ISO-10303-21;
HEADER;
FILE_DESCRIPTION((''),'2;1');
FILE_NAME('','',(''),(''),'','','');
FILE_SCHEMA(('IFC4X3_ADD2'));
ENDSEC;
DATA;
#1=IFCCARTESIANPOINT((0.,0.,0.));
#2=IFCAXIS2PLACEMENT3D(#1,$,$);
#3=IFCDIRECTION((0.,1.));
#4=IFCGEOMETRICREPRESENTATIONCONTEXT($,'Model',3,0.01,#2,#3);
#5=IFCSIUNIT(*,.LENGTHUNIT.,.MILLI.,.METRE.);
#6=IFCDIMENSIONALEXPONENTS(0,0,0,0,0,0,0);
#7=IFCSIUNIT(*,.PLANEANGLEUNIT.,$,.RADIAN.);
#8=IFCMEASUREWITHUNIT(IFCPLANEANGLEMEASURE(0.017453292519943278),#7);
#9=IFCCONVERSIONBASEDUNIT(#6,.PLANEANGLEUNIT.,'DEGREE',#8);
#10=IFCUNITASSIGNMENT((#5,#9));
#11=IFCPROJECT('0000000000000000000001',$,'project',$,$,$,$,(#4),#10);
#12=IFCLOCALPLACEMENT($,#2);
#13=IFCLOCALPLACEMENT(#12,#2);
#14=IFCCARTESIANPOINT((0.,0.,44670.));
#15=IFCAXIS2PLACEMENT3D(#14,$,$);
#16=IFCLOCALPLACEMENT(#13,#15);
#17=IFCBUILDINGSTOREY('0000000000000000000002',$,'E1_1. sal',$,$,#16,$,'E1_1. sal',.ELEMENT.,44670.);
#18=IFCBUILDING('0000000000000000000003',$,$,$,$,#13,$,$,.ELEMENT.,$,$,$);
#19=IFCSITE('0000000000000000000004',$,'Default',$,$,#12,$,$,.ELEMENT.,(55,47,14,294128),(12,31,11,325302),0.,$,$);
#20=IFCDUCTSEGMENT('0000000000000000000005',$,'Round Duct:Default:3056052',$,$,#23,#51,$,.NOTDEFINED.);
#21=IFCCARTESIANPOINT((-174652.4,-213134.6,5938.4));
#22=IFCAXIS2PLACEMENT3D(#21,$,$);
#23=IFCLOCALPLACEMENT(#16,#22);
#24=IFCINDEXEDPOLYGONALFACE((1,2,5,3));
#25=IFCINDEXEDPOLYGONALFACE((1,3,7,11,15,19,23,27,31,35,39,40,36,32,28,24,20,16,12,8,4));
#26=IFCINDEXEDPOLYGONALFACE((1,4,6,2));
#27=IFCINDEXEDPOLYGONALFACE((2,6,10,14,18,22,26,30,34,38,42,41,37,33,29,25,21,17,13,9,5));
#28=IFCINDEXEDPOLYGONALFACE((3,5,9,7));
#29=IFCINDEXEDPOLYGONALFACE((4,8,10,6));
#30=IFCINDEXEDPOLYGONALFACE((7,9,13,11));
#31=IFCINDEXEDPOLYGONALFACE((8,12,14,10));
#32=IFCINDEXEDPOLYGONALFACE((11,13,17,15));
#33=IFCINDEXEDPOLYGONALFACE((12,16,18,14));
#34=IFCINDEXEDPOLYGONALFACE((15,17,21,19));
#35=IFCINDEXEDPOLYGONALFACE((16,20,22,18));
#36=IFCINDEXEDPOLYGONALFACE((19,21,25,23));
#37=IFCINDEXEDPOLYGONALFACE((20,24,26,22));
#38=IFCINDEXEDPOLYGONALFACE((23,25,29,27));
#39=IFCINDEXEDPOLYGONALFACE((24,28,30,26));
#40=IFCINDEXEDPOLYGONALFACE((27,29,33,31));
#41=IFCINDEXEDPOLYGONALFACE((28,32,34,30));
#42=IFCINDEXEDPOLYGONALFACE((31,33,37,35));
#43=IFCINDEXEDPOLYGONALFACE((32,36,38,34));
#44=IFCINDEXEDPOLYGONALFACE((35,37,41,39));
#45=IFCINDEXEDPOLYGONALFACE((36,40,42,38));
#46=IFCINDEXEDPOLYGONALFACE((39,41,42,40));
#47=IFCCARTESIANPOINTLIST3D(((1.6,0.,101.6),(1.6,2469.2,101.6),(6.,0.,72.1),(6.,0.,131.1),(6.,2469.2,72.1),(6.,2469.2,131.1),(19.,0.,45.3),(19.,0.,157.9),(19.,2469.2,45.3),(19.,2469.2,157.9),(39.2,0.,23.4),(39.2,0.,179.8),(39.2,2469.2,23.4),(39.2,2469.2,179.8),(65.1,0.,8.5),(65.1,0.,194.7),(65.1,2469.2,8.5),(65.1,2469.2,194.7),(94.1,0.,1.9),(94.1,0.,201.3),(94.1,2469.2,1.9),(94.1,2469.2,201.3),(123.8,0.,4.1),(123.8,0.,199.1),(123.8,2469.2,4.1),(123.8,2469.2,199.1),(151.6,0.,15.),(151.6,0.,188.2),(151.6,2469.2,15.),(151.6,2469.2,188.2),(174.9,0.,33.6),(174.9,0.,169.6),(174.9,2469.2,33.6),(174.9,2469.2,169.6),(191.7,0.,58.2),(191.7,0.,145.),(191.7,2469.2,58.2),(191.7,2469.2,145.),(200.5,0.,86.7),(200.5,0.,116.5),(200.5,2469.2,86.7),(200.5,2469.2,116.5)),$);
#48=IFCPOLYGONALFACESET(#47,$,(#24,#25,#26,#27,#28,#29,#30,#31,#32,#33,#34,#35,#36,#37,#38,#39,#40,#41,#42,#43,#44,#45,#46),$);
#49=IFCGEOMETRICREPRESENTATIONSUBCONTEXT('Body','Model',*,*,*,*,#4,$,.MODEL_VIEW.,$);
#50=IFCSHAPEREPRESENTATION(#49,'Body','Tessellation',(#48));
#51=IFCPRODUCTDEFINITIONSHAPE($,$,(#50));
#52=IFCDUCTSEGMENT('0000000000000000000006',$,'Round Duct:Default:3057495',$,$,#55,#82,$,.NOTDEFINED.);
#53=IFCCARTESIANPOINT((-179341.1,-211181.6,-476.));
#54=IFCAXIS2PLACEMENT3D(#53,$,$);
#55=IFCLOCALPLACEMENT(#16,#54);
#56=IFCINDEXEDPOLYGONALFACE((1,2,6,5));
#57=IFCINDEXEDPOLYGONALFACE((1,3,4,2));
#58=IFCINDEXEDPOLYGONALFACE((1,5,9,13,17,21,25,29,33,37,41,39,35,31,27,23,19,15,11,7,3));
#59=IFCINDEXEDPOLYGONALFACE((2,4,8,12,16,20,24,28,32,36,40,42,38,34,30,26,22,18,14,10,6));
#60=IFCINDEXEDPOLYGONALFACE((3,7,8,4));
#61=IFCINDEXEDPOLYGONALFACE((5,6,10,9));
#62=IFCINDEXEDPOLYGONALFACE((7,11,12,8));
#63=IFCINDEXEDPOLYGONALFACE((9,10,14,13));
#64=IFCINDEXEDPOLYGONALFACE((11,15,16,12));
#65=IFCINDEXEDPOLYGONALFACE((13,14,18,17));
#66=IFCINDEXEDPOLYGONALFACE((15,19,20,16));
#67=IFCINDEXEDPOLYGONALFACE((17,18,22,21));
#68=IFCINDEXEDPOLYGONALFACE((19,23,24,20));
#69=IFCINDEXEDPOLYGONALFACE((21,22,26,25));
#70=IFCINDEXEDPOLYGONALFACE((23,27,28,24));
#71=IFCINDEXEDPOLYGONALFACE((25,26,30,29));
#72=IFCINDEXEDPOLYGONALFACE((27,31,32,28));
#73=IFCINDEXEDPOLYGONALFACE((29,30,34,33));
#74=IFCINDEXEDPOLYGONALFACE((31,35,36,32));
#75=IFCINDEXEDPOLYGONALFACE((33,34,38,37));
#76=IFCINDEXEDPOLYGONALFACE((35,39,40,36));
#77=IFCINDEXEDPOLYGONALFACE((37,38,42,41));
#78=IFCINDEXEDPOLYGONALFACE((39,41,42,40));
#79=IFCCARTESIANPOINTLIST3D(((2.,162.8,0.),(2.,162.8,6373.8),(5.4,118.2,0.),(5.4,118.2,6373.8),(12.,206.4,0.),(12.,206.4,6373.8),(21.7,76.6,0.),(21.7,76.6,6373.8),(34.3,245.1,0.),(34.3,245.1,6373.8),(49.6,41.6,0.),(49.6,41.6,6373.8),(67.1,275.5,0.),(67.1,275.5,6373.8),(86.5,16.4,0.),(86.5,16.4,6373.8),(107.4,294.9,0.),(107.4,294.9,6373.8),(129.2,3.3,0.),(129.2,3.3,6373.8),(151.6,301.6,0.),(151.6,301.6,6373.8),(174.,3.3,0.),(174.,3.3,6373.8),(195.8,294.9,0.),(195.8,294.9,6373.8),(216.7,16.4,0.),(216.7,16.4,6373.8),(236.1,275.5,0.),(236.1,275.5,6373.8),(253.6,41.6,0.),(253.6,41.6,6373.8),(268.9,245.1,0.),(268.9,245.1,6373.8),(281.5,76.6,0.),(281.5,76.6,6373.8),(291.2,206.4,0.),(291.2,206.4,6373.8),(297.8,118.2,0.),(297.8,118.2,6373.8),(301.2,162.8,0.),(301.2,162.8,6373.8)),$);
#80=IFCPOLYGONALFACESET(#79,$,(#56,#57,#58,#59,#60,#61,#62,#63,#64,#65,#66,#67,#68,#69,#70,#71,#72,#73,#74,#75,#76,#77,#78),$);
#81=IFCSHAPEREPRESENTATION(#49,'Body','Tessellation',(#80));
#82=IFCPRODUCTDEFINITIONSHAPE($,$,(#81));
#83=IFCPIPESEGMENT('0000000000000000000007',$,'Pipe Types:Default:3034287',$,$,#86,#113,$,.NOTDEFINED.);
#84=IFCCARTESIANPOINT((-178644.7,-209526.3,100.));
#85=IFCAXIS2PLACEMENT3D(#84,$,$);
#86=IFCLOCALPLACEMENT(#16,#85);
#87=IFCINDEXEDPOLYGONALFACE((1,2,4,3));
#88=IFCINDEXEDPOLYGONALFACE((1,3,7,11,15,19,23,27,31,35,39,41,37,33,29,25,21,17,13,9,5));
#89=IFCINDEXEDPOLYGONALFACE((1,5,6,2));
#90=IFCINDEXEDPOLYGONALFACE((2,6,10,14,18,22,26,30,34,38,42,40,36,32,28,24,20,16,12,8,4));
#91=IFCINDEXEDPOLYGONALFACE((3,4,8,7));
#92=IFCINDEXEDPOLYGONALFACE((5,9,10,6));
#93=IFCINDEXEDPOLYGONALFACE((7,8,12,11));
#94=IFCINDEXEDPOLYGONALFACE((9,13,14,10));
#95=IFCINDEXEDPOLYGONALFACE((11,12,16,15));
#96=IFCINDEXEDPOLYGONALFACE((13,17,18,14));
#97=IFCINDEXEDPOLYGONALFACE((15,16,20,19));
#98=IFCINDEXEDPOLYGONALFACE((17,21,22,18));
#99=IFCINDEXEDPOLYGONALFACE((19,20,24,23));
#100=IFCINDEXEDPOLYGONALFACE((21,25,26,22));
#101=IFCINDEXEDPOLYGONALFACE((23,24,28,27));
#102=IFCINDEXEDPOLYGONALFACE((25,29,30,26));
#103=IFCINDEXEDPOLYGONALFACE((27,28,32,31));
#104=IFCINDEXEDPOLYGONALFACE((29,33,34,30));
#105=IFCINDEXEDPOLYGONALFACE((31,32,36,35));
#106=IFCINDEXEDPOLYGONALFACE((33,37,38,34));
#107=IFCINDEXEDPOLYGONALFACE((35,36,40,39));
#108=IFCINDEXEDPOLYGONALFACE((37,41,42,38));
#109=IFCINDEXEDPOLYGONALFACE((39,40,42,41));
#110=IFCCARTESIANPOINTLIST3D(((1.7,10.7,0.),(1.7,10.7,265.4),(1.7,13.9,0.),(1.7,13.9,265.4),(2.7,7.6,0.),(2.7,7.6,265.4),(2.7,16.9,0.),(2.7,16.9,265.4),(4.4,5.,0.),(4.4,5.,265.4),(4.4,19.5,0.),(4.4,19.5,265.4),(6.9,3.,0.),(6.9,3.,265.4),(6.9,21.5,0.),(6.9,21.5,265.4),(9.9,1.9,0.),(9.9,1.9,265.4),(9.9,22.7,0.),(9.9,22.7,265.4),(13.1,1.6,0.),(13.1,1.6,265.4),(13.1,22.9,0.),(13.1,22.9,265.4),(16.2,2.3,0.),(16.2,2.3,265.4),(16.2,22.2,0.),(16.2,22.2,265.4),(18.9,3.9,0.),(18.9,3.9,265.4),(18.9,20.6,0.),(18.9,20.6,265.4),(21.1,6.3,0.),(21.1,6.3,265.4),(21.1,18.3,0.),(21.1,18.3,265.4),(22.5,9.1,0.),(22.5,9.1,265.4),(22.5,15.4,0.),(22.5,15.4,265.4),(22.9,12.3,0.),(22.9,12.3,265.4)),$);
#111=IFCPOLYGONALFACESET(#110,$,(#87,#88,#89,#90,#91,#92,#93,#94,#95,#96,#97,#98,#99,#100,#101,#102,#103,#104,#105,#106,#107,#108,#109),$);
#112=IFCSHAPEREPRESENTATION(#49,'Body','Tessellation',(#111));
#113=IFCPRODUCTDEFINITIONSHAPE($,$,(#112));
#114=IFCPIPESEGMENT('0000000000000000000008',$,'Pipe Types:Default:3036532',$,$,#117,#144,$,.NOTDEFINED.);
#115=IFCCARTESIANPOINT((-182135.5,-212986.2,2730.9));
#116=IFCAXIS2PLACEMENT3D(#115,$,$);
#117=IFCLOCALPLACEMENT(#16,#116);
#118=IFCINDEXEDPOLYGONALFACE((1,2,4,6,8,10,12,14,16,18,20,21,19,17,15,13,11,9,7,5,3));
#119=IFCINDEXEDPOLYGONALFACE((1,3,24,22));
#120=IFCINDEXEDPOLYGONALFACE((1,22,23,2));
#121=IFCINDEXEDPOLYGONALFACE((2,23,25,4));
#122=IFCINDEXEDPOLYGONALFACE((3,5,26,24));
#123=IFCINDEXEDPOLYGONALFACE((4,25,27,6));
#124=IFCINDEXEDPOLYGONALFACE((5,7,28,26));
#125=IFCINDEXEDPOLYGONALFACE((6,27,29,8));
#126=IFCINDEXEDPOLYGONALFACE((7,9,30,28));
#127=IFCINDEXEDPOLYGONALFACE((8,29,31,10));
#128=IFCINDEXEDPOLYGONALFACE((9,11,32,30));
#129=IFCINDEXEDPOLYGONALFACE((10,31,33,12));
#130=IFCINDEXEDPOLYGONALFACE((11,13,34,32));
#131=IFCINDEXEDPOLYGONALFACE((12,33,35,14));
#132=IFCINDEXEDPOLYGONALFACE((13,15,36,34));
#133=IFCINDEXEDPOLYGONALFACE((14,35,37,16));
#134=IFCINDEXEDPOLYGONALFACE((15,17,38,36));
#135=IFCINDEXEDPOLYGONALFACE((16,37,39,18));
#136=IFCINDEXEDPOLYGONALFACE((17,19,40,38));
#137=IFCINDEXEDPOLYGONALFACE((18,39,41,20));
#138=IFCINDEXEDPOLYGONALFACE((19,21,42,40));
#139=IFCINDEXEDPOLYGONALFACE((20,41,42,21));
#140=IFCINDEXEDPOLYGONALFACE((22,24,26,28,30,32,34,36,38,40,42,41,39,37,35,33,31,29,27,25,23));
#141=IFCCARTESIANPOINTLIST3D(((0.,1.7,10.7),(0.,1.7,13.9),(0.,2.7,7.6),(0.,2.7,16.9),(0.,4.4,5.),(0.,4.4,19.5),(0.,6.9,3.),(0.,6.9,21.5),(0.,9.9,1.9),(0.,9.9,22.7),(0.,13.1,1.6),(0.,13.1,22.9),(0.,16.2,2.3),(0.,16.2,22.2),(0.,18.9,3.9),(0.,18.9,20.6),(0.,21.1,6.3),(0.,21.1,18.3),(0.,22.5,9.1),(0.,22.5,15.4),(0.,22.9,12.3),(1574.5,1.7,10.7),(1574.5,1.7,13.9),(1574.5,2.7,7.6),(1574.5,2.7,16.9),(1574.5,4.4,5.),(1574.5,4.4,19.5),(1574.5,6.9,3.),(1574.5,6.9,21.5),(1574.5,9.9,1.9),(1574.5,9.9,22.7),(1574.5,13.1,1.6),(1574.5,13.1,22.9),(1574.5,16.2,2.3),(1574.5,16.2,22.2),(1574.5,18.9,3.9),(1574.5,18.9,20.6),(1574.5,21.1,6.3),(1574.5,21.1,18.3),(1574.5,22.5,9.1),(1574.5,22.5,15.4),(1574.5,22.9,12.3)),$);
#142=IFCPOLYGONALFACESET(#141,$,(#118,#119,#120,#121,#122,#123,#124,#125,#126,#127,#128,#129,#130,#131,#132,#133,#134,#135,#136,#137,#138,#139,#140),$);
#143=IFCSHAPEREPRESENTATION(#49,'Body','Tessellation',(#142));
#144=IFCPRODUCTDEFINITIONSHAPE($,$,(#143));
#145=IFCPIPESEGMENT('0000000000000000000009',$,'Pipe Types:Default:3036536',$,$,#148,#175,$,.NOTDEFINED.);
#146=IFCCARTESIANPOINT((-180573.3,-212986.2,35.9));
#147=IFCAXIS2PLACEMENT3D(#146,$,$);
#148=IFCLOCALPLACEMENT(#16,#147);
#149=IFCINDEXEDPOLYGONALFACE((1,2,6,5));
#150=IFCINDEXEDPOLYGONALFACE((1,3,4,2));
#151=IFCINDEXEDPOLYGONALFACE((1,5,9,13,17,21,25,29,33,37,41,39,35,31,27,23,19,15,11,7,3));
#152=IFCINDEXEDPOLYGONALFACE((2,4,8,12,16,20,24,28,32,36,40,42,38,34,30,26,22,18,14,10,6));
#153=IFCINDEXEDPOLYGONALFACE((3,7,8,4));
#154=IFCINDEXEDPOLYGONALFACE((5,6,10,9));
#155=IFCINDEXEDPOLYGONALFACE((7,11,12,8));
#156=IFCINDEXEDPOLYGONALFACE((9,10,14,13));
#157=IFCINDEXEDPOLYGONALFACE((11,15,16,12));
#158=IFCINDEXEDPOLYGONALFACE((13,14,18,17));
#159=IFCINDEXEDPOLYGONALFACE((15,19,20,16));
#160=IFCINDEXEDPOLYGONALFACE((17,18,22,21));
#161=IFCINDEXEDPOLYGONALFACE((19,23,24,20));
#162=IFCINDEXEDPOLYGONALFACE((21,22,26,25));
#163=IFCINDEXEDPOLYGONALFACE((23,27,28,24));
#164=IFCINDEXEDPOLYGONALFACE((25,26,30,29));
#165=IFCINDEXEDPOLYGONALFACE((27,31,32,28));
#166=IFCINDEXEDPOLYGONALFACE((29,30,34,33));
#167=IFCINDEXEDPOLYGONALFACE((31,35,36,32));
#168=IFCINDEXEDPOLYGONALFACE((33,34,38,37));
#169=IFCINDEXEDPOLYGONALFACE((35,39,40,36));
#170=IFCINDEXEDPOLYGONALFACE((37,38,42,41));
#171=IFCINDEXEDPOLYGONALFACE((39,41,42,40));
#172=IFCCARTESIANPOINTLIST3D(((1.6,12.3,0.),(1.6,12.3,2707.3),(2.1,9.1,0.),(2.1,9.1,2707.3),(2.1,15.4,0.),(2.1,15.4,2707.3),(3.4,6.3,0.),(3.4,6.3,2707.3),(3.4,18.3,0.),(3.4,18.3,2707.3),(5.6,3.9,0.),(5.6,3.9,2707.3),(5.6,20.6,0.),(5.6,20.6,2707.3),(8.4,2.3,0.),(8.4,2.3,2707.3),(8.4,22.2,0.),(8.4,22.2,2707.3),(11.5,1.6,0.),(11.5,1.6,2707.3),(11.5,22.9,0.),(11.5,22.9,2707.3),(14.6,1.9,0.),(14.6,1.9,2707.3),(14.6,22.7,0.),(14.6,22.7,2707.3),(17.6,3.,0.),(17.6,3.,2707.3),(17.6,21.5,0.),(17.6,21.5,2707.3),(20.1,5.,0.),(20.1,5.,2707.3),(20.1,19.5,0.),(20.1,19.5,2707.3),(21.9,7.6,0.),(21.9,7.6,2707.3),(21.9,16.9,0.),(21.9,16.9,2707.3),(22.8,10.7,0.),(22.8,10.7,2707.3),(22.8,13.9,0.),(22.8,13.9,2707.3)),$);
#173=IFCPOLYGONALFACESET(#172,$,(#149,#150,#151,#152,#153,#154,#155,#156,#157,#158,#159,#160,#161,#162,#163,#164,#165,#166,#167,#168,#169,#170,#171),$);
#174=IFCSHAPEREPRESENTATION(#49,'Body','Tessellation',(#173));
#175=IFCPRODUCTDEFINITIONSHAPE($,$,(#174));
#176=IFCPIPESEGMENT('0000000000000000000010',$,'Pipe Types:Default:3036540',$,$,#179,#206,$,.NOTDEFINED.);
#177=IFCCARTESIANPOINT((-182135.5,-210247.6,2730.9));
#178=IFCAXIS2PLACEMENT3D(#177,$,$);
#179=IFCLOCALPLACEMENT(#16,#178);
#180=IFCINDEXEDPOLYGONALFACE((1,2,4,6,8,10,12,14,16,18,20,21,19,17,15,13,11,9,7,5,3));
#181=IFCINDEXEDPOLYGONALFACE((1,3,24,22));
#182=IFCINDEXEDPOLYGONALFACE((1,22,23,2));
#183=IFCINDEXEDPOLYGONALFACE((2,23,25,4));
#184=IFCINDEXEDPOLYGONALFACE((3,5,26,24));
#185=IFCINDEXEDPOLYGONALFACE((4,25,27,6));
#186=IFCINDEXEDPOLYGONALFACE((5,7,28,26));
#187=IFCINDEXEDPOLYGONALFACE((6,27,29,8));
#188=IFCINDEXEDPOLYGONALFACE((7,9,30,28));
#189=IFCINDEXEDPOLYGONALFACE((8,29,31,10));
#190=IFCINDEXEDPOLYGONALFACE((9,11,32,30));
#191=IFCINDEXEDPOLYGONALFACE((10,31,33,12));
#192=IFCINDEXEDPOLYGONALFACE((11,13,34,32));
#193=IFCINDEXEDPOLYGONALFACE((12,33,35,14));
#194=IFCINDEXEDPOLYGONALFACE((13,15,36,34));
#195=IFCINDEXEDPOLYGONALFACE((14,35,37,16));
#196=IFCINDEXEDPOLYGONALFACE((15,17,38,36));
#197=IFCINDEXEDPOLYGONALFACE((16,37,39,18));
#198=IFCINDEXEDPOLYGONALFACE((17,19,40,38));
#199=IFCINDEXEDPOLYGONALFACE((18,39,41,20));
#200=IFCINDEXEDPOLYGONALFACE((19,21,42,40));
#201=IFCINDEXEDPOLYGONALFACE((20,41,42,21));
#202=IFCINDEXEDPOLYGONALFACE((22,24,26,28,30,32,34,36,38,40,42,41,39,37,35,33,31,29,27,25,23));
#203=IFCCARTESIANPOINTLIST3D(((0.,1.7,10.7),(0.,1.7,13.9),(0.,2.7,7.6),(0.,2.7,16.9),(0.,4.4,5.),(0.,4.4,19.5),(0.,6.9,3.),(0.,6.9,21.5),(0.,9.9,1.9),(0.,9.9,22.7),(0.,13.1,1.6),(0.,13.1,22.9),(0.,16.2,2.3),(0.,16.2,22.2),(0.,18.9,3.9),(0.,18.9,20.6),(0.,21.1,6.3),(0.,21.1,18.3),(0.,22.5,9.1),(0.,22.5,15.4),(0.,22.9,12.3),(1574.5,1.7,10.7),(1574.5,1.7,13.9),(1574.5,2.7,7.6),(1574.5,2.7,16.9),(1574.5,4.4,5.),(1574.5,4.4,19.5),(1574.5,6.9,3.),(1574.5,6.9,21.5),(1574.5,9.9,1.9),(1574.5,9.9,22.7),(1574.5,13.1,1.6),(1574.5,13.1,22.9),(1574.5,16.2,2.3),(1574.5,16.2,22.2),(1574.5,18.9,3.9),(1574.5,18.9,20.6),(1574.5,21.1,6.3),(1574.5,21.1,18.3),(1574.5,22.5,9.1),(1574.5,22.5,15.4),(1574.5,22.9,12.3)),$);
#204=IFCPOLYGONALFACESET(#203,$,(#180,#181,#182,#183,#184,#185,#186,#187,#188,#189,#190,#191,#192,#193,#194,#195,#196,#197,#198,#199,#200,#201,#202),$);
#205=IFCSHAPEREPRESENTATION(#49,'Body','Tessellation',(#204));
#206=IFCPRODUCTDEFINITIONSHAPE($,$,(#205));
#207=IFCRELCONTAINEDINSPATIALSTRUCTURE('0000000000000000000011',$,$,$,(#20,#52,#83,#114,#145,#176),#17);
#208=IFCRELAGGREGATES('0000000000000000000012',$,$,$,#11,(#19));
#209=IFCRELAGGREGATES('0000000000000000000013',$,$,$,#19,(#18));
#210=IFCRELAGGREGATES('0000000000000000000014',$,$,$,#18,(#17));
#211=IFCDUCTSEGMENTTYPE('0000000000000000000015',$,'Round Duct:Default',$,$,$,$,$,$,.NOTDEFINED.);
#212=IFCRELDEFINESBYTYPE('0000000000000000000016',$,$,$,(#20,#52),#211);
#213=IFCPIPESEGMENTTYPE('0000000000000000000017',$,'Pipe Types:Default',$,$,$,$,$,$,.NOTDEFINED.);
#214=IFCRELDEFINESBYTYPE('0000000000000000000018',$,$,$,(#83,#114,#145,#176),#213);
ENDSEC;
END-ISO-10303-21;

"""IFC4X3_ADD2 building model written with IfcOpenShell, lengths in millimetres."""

from ifc_helpers import new_model, entity, si_unit, converted_unit, direction, frame, frame_2d, origin, origin_2d_with_axis, place, context, subcontext, project, spatial, circle, extrude, type_object, element, save


model = new_model("IFC4X3_ADD2")

# Units and contexts
model_context = context("Model", 3, precision=0.01, world=origin(), true_north=direction((0.0, 1.0)))
body_context = subcontext(model_context, "Body", "Model", "MODEL_VIEW")
ifc_project = project(units=[si_unit("LENGTHUNIT", "METRE", prefix="MILLI"), converted_unit("PLANEANGLEUNIT", "DEGREE", entity("IfcPlaneAngleMeasure", 0.017453292519943278), si_unit("PLANEANGLEUNIT", "RADIAN"), dimensions=[0, 0, 0, 0, 0, 0, 0])], contexts=[model_context])

# Site, building, storey
site_placement = place(None, origin())
site = spatial("IfcSite", under=ifc_project, at=site_placement, Name="Default", CompositionType="ELEMENT", RefLatitude=(55, 47, 14, 294128), RefLongitude=(12, 31, 11, 325302), RefElevation=0.0)
building_placement = place(site_placement, origin())
building = spatial("IfcBuilding", under=site, at=building_placement, CompositionType="ELEMENT")
storey_placement = place(building_placement, frame((0.0, 0.0, 44670.0)))
storey = spatial("IfcBuildingStorey", under=building, at=storey_placement, Name="E1_1. sal", LongName="E1_1. sal", CompositionType="ELEMENT", Elevation=44670.0)

# Duct segments
duct_segment_type = type_object("IfcDuctSegmentType", Name="Round Duct:Default", PredefinedType="NOTDEFINED")
duct_segment_1_placement = place(storey_placement, frame((-174652.4, -213134.6, 5938.4)))
element("IfcDuctSegment", 1, at=duct_segment_1_placement, inside=storey, type_object=duct_segment_type, Name="Round Duct:Default:3056052", PredefinedType="NOTDEFINED", context=body_context, shape_type="SweptSolid", body=[
    extrude(circle(Radius=100.0, at=origin_2d_with_axis()), frame((101.6, 0.0, 101.6), z_axis=(0.0, 1.0, 0.0), x_axis=(-1.0, 0.0, 0.0)), (0.0, 0.0, 1.0), 2469.2),
])
duct_segment_2_placement = place(storey_placement, frame((-179341.1, -211181.6, -476.0)))
element("IfcDuctSegment", 2, at=duct_segment_2_placement, inside=storey, type_object=duct_segment_type, Name="Round Duct:Default:3057495", PredefinedType="NOTDEFINED", context=body_context, shape_type="SweptSolid", body=[
    extrude(circle(Radius=150.0, at=origin_2d_with_axis()), frame((151.6, 151.6, 0.0), z_axis=(0.0, 0.0, 1.0), x_axis=(0.0, 1.0, 0.0)), (0.0, 0.0, 1.0), 6373.8),
])

# Pipe segments
pipe_segment_type = type_object("IfcPipeSegmentType", Name="Pipe Types:Default", PredefinedType="NOTDEFINED")
pipe_segment_1_placement = place(storey_placement, frame((-178644.7, -209526.3, 100.0)))
element("IfcPipeSegment", 3, at=pipe_segment_1_placement, inside=storey, type_object=pipe_segment_type, Name="Pipe Types:Default:3034287", PredefinedType="NOTDEFINED", context=body_context, shape_type="SweptSolid", body=[
    extrude(circle(Radius=10.7, at=frame_2d((0.0, 0.0), x_axis=(1.0, 0.0))), frame((12.3, 12.3, 0.0)), (0.0, 0.0, 1.0), 265.4),
])
pipe_segment_2_placement = place(storey_placement, frame((-182135.5, -212986.2, 2730.9)))
element("IfcPipeSegment", 4, at=pipe_segment_2_placement, inside=storey, type_object=pipe_segment_type, Name="Pipe Types:Default:3036532", PredefinedType="NOTDEFINED", context=body_context, shape_type="SweptSolid", body=[
    extrude(circle(Radius=10.7, at=origin_2d_with_axis()), frame((0.0, 12.3, 12.3), z_axis=(1.0, 0.0, 0.0), x_axis=(0.0, 1.0, 0.0)), (0.0, 0.0, 1.0), 1574.5),
])
pipe_segment_3_placement = place(storey_placement, frame((-180573.3, -212986.2, 35.9)))
element("IfcPipeSegment", 5, at=pipe_segment_3_placement, inside=storey, type_object=pipe_segment_type, Name="Pipe Types:Default:3036536", PredefinedType="NOTDEFINED", context=body_context, shape_type="SweptSolid", body=[
    extrude(circle(Radius=10.7, at=frame_2d((0.0, 0.0), x_axis=(1.0, 0.0))), frame((12.3, 12.3, 0.0), z_axis=(0.0, 0.0, 1.0), x_axis=(-1.0, 0.0, 0.0)), (0.0, 0.0, 1.0), 2707.3),
])
pipe_segment_4_placement = place(storey_placement, frame((-182135.5, -210247.6, 2730.9)))
element("IfcPipeSegment", 6, at=pipe_segment_4_placement, inside=storey, type_object=pipe_segment_type, Name="Pipe Types:Default:3036540", PredefinedType="NOTDEFINED", context=body_context, shape_type="SweptSolid", body=[
    extrude(circle(Radius=10.7, at=origin_2d_with_axis()), frame((0.0, 12.3, 12.3), z_axis=(1.0, 0.0, 0.0), x_axis=(0.0, 1.0, 0.0)), (0.0, 0.0, 1.0), 1574.5),
])

save(model, "model.ifc")
